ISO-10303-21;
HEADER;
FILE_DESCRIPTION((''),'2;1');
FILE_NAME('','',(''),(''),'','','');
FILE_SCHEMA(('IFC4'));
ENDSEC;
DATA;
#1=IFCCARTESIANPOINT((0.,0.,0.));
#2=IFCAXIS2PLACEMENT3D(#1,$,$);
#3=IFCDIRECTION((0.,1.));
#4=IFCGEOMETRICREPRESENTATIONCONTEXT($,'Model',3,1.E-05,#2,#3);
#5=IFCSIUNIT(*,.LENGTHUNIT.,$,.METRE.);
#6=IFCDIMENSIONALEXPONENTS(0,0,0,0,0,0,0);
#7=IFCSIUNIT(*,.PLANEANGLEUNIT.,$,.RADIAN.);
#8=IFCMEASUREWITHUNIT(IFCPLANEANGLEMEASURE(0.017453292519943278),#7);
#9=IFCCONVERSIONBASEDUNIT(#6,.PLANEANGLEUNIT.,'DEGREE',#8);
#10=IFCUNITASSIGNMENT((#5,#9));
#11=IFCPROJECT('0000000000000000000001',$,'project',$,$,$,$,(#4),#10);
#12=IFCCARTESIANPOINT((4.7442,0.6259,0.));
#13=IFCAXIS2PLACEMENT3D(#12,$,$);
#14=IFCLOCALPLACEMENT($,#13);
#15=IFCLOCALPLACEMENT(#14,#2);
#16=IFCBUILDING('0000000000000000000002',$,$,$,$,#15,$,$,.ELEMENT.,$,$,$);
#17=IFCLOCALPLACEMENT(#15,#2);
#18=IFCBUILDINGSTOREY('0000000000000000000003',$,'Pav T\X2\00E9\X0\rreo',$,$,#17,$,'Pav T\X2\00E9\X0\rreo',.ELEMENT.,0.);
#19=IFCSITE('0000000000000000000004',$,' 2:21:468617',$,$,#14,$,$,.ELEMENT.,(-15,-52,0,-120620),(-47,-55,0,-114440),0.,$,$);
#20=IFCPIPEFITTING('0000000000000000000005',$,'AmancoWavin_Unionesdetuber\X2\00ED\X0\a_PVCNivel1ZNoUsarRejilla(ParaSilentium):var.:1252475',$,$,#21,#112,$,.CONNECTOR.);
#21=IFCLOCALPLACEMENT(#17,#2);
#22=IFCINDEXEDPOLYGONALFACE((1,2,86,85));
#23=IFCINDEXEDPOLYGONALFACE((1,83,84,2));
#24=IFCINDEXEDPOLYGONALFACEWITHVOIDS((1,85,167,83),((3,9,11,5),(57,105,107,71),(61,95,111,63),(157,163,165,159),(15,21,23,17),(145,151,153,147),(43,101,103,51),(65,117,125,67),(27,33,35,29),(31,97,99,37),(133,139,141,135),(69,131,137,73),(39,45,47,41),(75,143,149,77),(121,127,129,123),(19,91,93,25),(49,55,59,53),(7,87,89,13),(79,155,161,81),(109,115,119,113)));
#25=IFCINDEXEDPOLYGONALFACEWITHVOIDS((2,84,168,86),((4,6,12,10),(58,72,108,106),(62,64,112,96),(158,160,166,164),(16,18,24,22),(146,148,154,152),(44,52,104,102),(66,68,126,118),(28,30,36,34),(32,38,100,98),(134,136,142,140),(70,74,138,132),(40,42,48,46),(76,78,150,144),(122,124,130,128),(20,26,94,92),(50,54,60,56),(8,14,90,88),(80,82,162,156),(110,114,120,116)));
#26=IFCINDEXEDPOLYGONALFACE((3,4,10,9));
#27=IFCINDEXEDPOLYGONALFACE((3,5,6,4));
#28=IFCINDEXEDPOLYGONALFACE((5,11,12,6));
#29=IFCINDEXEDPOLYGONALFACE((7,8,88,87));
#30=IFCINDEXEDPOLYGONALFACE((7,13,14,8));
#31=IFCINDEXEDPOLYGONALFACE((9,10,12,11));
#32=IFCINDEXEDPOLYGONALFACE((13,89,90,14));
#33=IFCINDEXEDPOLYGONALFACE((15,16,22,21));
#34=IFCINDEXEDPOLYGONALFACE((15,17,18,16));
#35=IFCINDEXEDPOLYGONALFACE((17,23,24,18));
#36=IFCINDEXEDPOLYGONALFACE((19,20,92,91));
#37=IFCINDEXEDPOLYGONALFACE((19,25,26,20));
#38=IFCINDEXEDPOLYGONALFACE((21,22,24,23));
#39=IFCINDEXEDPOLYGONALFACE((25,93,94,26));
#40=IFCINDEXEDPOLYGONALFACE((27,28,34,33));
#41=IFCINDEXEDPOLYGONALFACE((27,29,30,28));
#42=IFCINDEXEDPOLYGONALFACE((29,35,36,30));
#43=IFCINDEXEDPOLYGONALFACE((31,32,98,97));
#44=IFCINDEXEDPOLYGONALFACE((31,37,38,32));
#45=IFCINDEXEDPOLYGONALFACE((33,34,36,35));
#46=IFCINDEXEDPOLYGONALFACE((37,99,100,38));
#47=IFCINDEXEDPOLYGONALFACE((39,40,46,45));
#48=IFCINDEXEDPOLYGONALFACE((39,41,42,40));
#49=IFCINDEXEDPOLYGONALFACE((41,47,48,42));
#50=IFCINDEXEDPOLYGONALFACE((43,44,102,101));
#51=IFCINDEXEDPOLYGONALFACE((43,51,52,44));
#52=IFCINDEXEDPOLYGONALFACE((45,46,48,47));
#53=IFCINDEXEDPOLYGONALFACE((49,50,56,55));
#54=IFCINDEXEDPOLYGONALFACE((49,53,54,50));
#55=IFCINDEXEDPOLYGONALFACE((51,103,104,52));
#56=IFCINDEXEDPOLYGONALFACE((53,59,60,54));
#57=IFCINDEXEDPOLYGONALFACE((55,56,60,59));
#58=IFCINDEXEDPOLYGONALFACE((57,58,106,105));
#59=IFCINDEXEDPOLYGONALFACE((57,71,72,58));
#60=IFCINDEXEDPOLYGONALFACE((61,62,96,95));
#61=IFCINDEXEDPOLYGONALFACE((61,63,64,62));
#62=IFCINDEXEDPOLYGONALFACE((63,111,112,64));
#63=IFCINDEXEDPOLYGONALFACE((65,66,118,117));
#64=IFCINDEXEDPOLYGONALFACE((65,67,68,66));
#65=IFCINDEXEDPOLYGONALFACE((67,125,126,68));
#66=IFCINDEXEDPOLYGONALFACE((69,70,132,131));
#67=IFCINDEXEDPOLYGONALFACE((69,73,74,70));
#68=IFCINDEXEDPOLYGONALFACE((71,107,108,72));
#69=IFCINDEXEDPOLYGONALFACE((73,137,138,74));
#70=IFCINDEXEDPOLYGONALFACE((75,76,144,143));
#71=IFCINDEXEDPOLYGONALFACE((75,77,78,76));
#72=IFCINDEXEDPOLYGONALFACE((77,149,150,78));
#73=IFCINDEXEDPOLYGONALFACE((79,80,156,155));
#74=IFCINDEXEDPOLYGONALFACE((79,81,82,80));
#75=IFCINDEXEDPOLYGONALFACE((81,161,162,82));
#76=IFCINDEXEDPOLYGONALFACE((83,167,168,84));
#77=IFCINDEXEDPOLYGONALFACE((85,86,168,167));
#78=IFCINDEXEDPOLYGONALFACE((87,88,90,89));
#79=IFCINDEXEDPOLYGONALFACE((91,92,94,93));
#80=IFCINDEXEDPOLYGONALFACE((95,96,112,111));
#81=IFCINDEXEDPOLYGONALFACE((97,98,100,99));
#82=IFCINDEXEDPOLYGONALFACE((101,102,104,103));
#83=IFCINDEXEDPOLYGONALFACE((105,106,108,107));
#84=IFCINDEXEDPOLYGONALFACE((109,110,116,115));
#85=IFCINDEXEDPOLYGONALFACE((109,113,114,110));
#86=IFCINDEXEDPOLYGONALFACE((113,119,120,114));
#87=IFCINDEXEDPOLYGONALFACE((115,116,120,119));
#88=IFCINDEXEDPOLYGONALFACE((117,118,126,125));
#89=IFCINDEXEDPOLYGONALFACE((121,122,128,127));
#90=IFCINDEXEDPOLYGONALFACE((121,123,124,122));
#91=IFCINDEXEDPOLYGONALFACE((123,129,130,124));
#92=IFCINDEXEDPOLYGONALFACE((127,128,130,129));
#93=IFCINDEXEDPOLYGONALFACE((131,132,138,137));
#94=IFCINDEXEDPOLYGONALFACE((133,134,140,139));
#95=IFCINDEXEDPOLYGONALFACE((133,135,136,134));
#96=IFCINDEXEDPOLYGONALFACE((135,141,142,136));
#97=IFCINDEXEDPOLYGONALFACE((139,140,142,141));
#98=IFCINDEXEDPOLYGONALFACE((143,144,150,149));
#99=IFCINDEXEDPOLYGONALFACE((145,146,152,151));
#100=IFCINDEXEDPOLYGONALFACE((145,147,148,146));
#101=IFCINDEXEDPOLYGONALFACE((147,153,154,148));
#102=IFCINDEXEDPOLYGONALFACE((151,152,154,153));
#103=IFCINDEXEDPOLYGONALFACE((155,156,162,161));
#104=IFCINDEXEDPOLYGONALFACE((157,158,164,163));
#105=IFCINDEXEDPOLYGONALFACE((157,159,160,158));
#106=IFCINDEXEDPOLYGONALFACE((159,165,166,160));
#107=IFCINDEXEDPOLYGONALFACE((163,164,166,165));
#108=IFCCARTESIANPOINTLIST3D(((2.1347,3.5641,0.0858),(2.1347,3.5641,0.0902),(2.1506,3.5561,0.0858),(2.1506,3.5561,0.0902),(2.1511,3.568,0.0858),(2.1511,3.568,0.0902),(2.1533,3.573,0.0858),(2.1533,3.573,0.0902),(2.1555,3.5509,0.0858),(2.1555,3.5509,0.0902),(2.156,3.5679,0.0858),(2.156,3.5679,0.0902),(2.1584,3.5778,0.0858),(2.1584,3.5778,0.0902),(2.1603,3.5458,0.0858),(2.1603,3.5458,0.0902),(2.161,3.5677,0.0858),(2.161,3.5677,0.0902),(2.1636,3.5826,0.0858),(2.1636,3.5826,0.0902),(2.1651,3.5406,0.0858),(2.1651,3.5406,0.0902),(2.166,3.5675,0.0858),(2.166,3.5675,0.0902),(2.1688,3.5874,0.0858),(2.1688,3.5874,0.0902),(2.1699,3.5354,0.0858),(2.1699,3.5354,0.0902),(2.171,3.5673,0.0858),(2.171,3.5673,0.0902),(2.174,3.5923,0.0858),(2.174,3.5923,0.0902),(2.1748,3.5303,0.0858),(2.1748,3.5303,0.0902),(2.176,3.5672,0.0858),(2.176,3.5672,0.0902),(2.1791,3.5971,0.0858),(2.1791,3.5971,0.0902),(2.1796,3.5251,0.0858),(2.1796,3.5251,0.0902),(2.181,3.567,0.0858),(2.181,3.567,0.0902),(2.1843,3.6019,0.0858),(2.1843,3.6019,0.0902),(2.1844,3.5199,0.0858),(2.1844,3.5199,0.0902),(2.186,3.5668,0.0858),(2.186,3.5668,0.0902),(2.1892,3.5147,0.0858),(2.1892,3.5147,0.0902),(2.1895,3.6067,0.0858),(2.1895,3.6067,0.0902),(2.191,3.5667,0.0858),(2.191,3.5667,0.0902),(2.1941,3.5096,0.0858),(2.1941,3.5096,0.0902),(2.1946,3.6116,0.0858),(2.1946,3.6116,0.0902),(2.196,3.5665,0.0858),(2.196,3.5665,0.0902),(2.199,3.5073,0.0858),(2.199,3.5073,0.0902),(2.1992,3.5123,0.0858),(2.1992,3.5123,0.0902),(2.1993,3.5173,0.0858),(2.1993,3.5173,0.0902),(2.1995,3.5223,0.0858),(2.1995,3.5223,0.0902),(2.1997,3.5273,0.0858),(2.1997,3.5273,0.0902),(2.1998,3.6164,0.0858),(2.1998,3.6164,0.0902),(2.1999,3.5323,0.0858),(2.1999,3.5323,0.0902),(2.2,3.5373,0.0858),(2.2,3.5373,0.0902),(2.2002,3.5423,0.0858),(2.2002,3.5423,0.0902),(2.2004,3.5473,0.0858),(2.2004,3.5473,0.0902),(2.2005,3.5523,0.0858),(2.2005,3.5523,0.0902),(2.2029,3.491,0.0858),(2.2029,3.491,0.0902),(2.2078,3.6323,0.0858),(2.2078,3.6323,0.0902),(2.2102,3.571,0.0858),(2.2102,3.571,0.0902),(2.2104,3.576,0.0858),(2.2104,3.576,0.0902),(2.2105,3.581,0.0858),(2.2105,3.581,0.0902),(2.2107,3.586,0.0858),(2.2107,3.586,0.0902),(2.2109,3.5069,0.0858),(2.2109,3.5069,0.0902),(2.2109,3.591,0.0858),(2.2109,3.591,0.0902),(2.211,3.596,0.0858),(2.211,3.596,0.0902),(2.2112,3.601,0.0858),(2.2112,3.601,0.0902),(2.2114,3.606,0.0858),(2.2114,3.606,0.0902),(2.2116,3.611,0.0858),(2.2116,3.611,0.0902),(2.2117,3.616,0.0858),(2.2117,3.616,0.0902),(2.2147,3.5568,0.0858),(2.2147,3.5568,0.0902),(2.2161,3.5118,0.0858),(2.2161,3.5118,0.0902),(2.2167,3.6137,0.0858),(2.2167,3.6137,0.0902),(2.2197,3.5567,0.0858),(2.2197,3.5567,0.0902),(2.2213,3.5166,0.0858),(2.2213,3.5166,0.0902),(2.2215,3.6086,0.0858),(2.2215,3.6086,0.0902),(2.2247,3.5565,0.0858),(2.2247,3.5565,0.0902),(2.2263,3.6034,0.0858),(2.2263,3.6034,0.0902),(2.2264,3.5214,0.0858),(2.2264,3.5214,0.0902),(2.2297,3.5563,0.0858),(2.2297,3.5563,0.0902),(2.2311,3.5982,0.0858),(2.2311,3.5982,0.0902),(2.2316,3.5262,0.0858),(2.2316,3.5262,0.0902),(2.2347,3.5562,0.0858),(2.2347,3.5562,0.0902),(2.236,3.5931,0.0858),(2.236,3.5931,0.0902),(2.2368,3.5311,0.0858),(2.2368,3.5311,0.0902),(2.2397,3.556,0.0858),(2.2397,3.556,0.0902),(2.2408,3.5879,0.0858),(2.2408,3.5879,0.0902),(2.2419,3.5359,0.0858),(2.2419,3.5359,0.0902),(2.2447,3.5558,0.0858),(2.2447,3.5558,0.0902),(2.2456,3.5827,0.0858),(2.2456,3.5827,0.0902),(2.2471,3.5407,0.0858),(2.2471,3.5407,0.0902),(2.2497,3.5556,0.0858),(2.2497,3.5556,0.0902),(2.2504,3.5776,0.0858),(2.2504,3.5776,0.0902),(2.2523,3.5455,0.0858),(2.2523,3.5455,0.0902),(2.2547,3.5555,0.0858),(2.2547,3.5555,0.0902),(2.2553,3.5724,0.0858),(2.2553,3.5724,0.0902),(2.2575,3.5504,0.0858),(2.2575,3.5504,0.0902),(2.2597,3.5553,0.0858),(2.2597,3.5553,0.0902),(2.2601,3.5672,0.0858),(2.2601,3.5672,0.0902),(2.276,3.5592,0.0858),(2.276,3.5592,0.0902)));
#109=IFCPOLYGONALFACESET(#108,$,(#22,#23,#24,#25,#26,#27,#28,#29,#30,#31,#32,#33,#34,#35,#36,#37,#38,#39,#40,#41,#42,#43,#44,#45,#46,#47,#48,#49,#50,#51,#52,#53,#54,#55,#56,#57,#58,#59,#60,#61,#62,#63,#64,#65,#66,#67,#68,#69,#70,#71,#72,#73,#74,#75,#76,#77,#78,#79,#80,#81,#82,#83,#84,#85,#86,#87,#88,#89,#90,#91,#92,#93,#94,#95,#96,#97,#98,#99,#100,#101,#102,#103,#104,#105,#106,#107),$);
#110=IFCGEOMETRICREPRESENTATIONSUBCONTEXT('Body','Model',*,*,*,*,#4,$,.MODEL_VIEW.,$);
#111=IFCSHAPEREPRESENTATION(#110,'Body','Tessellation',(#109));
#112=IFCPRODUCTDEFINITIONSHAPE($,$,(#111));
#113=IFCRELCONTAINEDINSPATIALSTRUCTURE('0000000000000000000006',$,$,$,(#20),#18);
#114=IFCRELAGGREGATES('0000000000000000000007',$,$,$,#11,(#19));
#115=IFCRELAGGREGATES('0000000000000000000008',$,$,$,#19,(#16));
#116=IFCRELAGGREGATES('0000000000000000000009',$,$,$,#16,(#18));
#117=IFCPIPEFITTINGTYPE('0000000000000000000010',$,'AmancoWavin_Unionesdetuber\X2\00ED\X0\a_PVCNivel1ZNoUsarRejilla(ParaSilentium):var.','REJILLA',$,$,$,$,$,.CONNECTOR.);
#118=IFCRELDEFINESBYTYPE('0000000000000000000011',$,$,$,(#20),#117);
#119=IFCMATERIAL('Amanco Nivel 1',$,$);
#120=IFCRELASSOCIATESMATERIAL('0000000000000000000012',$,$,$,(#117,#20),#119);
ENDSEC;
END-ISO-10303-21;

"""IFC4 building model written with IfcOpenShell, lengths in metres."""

from ifc_helpers import new_model, entity, si_unit, converted_unit, direction, frame, origin, place, context, subcontext, project, spatial, indexed_curve, outline, extrude, source, transform, mapped, material, type_object, type_shapes, element, save


model = new_model("IFC4")

# Units and contexts
model_context = context("Model", 3, precision=1e-05, world=origin(), true_north=direction((0.0, 1.0)))
body_context = subcontext(model_context, "Body", "Model", "MODEL_VIEW")
ifc_project = project(units=[si_unit("LENGTHUNIT", "METRE"), converted_unit("PLANEANGLEUNIT", "DEGREE", entity("IfcPlaneAngleMeasure", 0.017453292519943278), si_unit("PLANEANGLEUNIT", "RADIAN"), dimensions=[0, 0, 0, 0, 0, 0, 0])], contexts=[model_context])

# Site, building, storey
site_placement = place(None, frame((4.7442, 0.6259, 0.0)))
site = spatial("IfcSite", under=ifc_project, at=site_placement, Name=" 2:21:468617", CompositionType="ELEMENT", RefLatitude=(-15, -52, 0, -120620), RefLongitude=(-47, -55, 0, -114440), RefElevation=0.0)
building_placement = place(site_placement, origin())
building = spatial("IfcBuilding", under=site, at=building_placement, CompositionType="ELEMENT")
storey_placement = place(building_placement, origin())
storey = spatial("IfcBuildingStorey", under=building, at=storey_placement, Name="Pav Térreo", LongName="Pav Térreo", CompositionType="ELEMENT", Elevation=0.0)

# Pipe fitting
ifc_material_1 = material(Name="Amanco Nivel 1")
pipe_fitting_type = type_object("IfcPipeFittingType", Name="AmancoWavin_Unionesdetubería_PVCNivel1ZNoUsarRejilla(ParaSilentium):var.", Description="REJILLA", PredefinedType="CONNECTOR", material=ifc_material_1)
shared_shape = source(origin(), body_context, "Body", "SweptSolid", [
    extrude(outline(indexed_curve([(-0.05, -0.05), (0.05, -0.05), (0.05, 0.05), (-0.05, 0.05), (-0.05, -0.05)], self_intersect=False), holes=[indexed_curve([(0.0417, 0.0354), (0.0382, 0.0318), (0.0262, 0.0438), (0.0333, 0.0438), (0.0417, 0.0354)], self_intersect=False), indexed_curve([(0.0346, 0.0283), (0.0311, 0.0247), (0.0121, 0.0438), (0.0191, 0.0438), (0.0346, 0.0283)], self_intersect=False), indexed_curve([(0.0276, 0.0212), (0.024, 0.0177), (-0.0021, 0.0438), (0.005, 0.0438), (0.0276, 0.0212)], self_intersect=False), indexed_curve([(0.0205, 0.0141), (0.017, 0.0106), (-0.0162, 0.0438), (-0.0092, 0.0438), (0.0205, 0.0141)], self_intersect=False), indexed_curve([(0.0134, 0.0071), (0.0099, 0.0035), (-0.0304, 0.0438), (-0.0233, 0.0438), (0.0134, 0.0071)], self_intersect=False), indexed_curve([(-0.0354, 0.0417), (-0.0318, 0.0382), (-0.0438, 0.0262), (-0.0438, 0.0333), (-0.0354, 0.0417)], self_intersect=False), indexed_curve([(-0.0283, 0.0346), (-0.0247, 0.0311), (-0.0438, 0.0121), (-0.0438, 0.0191), (-0.0283, 0.0346)], self_intersect=False), indexed_curve([(-0.0212, 0.0276), (-0.0177, 0.024), (-0.0438, -0.0021), (-0.0438, 0.005), (-0.0212, 0.0276)], self_intersect=False), indexed_curve([(-0.0141, 0.0205), (-0.0106, 0.017), (-0.0438, -0.0162), (-0.0438, -0.0092), (-0.0141, 0.0205)], self_intersect=False), indexed_curve([(-0.0071, 0.0134), (-0.0035, 0.0099), (-0.0438, -0.0304), (-0.0438, -0.0233), (-0.0071, 0.0134)], self_intersect=False), indexed_curve([(-0.0417, -0.0354), (-0.0382, -0.0318), (-0.0262, -0.0438), (-0.0333, -0.0438), (-0.0417, -0.0354)], self_intersect=False), indexed_curve([(-0.0346, -0.0283), (-0.0311, -0.0247), (-0.0121, -0.0438), (-0.0191, -0.0438), (-0.0346, -0.0283)], self_intersect=False), indexed_curve([(-0.0276, -0.0212), (-0.024, -0.0177), (0.0021, -0.0438), (-0.005, -0.0438), (-0.0276, -0.0212)], self_intersect=False), indexed_curve([(-0.0205, -0.0141), (-0.017, -0.0106), (0.0162, -0.0438), (0.0092, -0.0438), (-0.0205, -0.0141)], self_intersect=False), indexed_curve([(-0.0134, -0.0071), (-0.0099, -0.0035), (0.0304, -0.0438), (0.0233, -0.0438), (-0.0134, -0.0071)], self_intersect=False), indexed_curve([(0.0354, -0.0417), (0.0318, -0.0382), (0.0438, -0.0262), (0.0438, -0.0333), (0.0354, -0.0417)], self_intersect=False), indexed_curve([(0.0283, -0.0346), (0.0247, -0.0311), (0.0438, -0.0121), (0.0438, -0.0191), (0.0283, -0.0346)], self_intersect=False), indexed_curve([(0.0212, -0.0276), (0.0177, -0.024), (0.0438, 0.0021), (0.0438, -0.005), (0.0212, -0.0276)], self_intersect=False), indexed_curve([(0.0141, -0.0205), (0.0106, -0.017), (0.0438, 0.0162), (0.0438, 0.0092), (0.0141, -0.0205)], self_intersect=False), indexed_curve([(0.0071, -0.0134), (0.0035, -0.0099), (0.0438, 0.0304), (0.0438, 0.0233), (0.0071, -0.0134)], self_intersect=False)]), frame((-0.0692, 0.0, -0.0042), z_axis=(0.0, 0.0, 1.0), x_axis=(-1.0, 0.0, 0.0)), (0.0, 0.0, 1.0), 0.0044),
])
type_shapes(pipe_fitting_type, [shared_shape])
pipe_fitting_placement = place(storey_placement, frame((2.256, 3.6089, 0.09), z_axis=(0.0, 0.0, 1.0), x_axis=(0.730915, 0.682468, 0.0)))
element("IfcPipeFitting", 1, at=pipe_fitting_placement, inside=storey, type_object=pipe_fitting_type, material=ifc_material_1, Name="AmancoWavin_Unionesdetubería_PVCNivel1ZNoUsarRejilla(ParaSilentium):var.:1252475", PredefinedType="CONNECTOR", context=body_context, shape_type="MappedRepresentation", body=[
    mapped(shared_shape, transform((0.0, 0.0, 0.0), scale=1.0)),
])

save(model, "model.ifc")
